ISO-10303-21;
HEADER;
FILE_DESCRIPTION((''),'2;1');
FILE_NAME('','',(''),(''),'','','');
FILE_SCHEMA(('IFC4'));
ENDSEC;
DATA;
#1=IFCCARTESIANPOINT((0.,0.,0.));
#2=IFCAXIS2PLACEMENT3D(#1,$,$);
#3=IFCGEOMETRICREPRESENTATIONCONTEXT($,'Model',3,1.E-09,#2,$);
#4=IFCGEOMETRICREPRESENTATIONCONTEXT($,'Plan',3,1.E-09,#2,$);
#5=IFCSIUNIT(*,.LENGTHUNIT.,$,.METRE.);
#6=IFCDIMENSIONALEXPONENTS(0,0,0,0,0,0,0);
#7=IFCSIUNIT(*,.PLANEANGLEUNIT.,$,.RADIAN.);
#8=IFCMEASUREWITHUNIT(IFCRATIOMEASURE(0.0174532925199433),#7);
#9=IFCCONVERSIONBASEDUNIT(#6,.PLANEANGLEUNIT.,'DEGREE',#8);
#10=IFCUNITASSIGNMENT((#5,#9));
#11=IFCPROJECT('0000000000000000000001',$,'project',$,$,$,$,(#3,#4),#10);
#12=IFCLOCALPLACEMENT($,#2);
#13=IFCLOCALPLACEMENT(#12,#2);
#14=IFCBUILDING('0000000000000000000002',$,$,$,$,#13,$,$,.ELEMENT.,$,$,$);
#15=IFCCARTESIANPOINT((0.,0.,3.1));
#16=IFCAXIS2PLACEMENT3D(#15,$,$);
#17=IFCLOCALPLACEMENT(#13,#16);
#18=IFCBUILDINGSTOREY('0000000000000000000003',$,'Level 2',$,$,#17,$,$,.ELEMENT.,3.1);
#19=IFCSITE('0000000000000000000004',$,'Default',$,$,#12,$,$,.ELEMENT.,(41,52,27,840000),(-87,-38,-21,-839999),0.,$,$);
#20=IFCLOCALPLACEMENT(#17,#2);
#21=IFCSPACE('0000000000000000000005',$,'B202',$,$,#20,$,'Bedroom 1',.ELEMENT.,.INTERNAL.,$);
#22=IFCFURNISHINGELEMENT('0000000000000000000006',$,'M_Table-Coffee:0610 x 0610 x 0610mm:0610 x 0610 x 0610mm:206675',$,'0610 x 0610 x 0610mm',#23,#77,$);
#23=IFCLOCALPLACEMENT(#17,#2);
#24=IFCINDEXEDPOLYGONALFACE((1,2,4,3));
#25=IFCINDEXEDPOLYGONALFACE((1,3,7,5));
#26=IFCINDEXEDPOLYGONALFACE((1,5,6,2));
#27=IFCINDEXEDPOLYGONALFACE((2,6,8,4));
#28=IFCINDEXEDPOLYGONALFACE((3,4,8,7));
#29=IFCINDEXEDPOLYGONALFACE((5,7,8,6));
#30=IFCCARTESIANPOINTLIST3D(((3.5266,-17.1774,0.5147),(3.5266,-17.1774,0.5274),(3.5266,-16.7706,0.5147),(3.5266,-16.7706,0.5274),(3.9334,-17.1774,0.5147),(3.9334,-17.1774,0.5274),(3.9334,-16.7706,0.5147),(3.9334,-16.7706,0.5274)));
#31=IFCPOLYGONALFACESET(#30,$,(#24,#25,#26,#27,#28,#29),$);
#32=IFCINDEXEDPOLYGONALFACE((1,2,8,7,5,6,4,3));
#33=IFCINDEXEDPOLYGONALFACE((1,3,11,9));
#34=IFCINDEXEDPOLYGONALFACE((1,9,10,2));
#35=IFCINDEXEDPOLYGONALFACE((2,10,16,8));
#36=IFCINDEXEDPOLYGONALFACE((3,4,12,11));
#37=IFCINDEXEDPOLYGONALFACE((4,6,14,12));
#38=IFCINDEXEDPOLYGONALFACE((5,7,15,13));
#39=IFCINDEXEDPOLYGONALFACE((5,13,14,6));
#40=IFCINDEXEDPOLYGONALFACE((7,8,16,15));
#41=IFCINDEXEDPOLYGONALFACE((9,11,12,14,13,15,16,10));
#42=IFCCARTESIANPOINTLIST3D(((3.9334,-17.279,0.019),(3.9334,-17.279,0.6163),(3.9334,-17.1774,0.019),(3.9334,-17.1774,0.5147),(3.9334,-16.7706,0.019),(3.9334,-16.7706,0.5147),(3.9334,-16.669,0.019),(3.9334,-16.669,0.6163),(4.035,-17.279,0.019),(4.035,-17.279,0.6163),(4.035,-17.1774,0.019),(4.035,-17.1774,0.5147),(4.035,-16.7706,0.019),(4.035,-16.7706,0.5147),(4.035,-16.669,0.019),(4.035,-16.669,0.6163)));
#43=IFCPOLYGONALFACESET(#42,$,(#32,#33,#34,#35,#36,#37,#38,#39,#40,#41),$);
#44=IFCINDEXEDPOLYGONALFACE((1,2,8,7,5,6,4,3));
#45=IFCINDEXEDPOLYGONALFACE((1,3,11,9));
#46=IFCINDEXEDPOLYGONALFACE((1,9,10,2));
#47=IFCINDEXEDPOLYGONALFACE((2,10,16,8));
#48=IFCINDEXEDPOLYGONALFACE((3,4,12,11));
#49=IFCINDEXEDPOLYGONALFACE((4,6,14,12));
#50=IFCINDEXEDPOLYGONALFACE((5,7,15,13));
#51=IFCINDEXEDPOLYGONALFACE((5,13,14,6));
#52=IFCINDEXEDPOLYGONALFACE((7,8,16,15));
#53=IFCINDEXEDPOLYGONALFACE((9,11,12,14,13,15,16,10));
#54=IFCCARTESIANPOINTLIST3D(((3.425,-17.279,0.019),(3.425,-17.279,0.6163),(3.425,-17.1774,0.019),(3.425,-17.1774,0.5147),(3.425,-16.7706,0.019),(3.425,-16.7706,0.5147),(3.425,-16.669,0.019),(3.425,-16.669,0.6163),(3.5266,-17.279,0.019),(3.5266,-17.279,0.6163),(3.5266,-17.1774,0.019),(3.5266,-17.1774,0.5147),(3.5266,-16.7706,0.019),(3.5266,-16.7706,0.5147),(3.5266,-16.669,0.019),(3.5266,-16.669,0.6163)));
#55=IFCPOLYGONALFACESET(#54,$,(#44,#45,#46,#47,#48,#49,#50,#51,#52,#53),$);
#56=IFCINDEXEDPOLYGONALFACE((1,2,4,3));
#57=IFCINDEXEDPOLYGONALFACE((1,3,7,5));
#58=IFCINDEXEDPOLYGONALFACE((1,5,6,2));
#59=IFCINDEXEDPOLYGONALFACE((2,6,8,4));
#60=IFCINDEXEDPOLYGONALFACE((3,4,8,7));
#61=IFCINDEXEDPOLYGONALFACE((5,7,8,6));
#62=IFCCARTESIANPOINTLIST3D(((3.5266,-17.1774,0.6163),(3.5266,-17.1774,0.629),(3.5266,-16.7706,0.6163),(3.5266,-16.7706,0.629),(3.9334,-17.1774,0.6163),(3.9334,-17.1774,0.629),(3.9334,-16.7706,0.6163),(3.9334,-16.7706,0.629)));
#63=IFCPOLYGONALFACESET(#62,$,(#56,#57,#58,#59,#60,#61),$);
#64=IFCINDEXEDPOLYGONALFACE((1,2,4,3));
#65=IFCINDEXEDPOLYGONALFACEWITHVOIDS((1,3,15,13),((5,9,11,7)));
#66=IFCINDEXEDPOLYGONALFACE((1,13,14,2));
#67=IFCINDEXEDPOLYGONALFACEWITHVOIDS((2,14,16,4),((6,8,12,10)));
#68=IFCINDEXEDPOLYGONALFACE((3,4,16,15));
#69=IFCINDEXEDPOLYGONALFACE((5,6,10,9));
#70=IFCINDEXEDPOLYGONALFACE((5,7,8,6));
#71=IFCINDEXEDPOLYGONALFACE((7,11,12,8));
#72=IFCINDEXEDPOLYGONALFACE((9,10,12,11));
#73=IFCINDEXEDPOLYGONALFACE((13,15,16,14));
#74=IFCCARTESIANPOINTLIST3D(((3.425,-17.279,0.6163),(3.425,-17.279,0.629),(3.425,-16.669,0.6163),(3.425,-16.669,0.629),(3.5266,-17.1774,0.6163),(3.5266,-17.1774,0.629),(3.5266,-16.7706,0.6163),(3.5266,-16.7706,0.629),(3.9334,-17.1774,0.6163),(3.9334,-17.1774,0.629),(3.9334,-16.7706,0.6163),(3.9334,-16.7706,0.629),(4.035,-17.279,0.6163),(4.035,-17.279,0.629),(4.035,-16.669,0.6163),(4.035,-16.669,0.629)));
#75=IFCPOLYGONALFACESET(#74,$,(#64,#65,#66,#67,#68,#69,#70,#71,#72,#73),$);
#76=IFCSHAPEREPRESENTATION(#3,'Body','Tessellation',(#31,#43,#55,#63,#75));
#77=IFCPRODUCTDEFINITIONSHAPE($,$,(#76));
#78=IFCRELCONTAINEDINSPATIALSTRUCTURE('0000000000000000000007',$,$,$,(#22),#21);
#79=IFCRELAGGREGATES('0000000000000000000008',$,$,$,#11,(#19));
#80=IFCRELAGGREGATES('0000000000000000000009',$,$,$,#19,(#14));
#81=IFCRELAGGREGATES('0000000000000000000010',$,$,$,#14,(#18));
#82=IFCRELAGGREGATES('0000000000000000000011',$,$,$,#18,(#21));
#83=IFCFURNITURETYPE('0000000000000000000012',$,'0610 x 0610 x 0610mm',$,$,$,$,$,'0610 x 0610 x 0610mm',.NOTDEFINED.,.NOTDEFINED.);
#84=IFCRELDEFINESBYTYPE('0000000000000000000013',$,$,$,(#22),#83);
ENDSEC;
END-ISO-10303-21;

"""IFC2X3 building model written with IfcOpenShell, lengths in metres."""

from ifc_helpers import new_model, entity, si_unit, converted_unit, frame, origin, origin_2d_with_axis, place, context, project, spatial, polyline, rectangle, outline, extrude, source, transform, mapped, type_object, type_shapes, element, save


model = new_model("IFC2X3")

# Units and contexts
model_context = context("Model", 3, precision=1e-09, world=origin())
plan_context = context("Plan", 3, precision=1e-09, world=origin())
ifc_project = project(units=[si_unit("LENGTHUNIT", "METRE"), converted_unit("PLANEANGLEUNIT", "DEGREE", entity("IfcRatioMeasure", 0.0174532925199433), si_unit("PLANEANGLEUNIT", "RADIAN"), dimensions=[0, 0, 0, 0, 0, 0, 0])], contexts=[model_context, plan_context])

# Site, building, storey
site_placement = place(None, origin())
site = spatial("IfcSite", under=ifc_project, at=site_placement, Name="Default", CompositionType="ELEMENT", RefLatitude=(41, 52, 27, 840000), RefLongitude=(-87, -38, -21, -839999), RefElevation=0.0)
building_placement = place(site_placement, origin())
building = spatial("IfcBuilding", under=site, at=building_placement, CompositionType="ELEMENT")
storey_placement = place(building_placement, frame((0.0, 0.0, 3.1)))
storey = spatial("IfcBuildingStorey", under=building, at=storey_placement, Name="Level 2", CompositionType="ELEMENT", Elevation=3.1)

# Shared definitions
space_placement = place(storey_placement, origin())
space = spatial("IfcSpace", under=storey, at=space_placement, Name="B202", LongName="Bedroom 1", CompositionType="ELEMENT", InteriorOrExteriorSpace="INTERNAL")

# Furnishing element
furniture_type = type_object("IfcFurnitureType", Name="0610 x 0610 x 0610mm", ElementType="0610 x 0610 x 0610mm", AssemblyPlace="NOTDEFINED")
shared_shape_1 = source(origin(), model_context, "Body", "SweptSolid", [
    extrude(rectangle(XDim=0.4068, YDim=0.4068, at=origin_2d_with_axis()), frame((0.0183, 0.0952, 0.4957), z_axis=(0.0, 0.0, 1.0), x_axis=(-1.0, 0.0, 0.0)), (0.0, 0.0, 1.0), 0.0127),
    extrude(outline(polyline([(-0.2732, -0.305), (0.324, -0.305), (0.324, 0.305), (-0.2732, 0.305), (-0.2732, 0.2034), (0.2225, 0.2034), (0.2225, -0.2034), (-0.2732, -0.2034), (-0.2732, -0.305)])), frame((0.2217, 0.0952, 0.2732), z_axis=(1.0, 0.0, 0.0), x_axis=(0.0, 0.0, 1.0)), (0.0, 0.0, 1.0), 0.1016),
    extrude(outline(polyline([(-0.305, -0.3241), (0.305, -0.3241), (0.305, 0.2733), (0.2034, 0.2733), (0.2034, -0.2224), (-0.2034, -0.2224), (-0.2034, 0.2733), (-0.305, 0.2733), (-0.305, -0.3241)])), frame((-0.2867, 0.0952, 0.2733), z_axis=(1.0, 0.0, 0.0), x_axis=(0.0, -1.0, 0.0)), (0.0, 0.0, 1.0), 0.1016),
    extrude(rectangle(XDim=0.4068, YDim=0.4068, at=origin_2d_with_axis()), frame((0.0183, 0.0952, 0.5973), z_axis=(0.0, 0.0, 1.0), x_axis=(-1.0, 0.0, 0.0)), (0.0, 0.0, 1.0), 0.0127),
    extrude(outline(polyline([(-0.305, -0.305), (0.305, -0.305), (0.305, 0.305), (-0.305, 0.305), (-0.305, -0.305)]), holes=[polyline([(-0.2034, -0.2034), (-0.2034, 0.2034), (0.2034, 0.2034), (0.2034, -0.2034), (-0.2034, -0.2034)])]), frame((0.0183, 0.0952, 0.5973), z_axis=(0.0, 0.0, 1.0), x_axis=(-1.0, 0.0, 0.0)), (0.0, 0.0, 1.0), 0.0127),
])
type_shapes(furniture_type, [shared_shape_1])
furnishing_placement = place(space_placement, frame((3.7117, -17.0692, 0.019)))
element("IfcFurnishingElement", 1, at=furnishing_placement, inside=space, type_object=furniture_type, Name="M_Table-Coffee:0610 x 0610 x 0610mm:0610 x 0610 x 0610mm:206675", ObjectType="0610 x 0610 x 0610mm", context=model_context, shape_type="MappedRepresentation", body=[
    mapped(shared_shape_1, transform((0.0, 0.0, 0.0), scale=1.0)),
])

save(model, "model.ifc")
